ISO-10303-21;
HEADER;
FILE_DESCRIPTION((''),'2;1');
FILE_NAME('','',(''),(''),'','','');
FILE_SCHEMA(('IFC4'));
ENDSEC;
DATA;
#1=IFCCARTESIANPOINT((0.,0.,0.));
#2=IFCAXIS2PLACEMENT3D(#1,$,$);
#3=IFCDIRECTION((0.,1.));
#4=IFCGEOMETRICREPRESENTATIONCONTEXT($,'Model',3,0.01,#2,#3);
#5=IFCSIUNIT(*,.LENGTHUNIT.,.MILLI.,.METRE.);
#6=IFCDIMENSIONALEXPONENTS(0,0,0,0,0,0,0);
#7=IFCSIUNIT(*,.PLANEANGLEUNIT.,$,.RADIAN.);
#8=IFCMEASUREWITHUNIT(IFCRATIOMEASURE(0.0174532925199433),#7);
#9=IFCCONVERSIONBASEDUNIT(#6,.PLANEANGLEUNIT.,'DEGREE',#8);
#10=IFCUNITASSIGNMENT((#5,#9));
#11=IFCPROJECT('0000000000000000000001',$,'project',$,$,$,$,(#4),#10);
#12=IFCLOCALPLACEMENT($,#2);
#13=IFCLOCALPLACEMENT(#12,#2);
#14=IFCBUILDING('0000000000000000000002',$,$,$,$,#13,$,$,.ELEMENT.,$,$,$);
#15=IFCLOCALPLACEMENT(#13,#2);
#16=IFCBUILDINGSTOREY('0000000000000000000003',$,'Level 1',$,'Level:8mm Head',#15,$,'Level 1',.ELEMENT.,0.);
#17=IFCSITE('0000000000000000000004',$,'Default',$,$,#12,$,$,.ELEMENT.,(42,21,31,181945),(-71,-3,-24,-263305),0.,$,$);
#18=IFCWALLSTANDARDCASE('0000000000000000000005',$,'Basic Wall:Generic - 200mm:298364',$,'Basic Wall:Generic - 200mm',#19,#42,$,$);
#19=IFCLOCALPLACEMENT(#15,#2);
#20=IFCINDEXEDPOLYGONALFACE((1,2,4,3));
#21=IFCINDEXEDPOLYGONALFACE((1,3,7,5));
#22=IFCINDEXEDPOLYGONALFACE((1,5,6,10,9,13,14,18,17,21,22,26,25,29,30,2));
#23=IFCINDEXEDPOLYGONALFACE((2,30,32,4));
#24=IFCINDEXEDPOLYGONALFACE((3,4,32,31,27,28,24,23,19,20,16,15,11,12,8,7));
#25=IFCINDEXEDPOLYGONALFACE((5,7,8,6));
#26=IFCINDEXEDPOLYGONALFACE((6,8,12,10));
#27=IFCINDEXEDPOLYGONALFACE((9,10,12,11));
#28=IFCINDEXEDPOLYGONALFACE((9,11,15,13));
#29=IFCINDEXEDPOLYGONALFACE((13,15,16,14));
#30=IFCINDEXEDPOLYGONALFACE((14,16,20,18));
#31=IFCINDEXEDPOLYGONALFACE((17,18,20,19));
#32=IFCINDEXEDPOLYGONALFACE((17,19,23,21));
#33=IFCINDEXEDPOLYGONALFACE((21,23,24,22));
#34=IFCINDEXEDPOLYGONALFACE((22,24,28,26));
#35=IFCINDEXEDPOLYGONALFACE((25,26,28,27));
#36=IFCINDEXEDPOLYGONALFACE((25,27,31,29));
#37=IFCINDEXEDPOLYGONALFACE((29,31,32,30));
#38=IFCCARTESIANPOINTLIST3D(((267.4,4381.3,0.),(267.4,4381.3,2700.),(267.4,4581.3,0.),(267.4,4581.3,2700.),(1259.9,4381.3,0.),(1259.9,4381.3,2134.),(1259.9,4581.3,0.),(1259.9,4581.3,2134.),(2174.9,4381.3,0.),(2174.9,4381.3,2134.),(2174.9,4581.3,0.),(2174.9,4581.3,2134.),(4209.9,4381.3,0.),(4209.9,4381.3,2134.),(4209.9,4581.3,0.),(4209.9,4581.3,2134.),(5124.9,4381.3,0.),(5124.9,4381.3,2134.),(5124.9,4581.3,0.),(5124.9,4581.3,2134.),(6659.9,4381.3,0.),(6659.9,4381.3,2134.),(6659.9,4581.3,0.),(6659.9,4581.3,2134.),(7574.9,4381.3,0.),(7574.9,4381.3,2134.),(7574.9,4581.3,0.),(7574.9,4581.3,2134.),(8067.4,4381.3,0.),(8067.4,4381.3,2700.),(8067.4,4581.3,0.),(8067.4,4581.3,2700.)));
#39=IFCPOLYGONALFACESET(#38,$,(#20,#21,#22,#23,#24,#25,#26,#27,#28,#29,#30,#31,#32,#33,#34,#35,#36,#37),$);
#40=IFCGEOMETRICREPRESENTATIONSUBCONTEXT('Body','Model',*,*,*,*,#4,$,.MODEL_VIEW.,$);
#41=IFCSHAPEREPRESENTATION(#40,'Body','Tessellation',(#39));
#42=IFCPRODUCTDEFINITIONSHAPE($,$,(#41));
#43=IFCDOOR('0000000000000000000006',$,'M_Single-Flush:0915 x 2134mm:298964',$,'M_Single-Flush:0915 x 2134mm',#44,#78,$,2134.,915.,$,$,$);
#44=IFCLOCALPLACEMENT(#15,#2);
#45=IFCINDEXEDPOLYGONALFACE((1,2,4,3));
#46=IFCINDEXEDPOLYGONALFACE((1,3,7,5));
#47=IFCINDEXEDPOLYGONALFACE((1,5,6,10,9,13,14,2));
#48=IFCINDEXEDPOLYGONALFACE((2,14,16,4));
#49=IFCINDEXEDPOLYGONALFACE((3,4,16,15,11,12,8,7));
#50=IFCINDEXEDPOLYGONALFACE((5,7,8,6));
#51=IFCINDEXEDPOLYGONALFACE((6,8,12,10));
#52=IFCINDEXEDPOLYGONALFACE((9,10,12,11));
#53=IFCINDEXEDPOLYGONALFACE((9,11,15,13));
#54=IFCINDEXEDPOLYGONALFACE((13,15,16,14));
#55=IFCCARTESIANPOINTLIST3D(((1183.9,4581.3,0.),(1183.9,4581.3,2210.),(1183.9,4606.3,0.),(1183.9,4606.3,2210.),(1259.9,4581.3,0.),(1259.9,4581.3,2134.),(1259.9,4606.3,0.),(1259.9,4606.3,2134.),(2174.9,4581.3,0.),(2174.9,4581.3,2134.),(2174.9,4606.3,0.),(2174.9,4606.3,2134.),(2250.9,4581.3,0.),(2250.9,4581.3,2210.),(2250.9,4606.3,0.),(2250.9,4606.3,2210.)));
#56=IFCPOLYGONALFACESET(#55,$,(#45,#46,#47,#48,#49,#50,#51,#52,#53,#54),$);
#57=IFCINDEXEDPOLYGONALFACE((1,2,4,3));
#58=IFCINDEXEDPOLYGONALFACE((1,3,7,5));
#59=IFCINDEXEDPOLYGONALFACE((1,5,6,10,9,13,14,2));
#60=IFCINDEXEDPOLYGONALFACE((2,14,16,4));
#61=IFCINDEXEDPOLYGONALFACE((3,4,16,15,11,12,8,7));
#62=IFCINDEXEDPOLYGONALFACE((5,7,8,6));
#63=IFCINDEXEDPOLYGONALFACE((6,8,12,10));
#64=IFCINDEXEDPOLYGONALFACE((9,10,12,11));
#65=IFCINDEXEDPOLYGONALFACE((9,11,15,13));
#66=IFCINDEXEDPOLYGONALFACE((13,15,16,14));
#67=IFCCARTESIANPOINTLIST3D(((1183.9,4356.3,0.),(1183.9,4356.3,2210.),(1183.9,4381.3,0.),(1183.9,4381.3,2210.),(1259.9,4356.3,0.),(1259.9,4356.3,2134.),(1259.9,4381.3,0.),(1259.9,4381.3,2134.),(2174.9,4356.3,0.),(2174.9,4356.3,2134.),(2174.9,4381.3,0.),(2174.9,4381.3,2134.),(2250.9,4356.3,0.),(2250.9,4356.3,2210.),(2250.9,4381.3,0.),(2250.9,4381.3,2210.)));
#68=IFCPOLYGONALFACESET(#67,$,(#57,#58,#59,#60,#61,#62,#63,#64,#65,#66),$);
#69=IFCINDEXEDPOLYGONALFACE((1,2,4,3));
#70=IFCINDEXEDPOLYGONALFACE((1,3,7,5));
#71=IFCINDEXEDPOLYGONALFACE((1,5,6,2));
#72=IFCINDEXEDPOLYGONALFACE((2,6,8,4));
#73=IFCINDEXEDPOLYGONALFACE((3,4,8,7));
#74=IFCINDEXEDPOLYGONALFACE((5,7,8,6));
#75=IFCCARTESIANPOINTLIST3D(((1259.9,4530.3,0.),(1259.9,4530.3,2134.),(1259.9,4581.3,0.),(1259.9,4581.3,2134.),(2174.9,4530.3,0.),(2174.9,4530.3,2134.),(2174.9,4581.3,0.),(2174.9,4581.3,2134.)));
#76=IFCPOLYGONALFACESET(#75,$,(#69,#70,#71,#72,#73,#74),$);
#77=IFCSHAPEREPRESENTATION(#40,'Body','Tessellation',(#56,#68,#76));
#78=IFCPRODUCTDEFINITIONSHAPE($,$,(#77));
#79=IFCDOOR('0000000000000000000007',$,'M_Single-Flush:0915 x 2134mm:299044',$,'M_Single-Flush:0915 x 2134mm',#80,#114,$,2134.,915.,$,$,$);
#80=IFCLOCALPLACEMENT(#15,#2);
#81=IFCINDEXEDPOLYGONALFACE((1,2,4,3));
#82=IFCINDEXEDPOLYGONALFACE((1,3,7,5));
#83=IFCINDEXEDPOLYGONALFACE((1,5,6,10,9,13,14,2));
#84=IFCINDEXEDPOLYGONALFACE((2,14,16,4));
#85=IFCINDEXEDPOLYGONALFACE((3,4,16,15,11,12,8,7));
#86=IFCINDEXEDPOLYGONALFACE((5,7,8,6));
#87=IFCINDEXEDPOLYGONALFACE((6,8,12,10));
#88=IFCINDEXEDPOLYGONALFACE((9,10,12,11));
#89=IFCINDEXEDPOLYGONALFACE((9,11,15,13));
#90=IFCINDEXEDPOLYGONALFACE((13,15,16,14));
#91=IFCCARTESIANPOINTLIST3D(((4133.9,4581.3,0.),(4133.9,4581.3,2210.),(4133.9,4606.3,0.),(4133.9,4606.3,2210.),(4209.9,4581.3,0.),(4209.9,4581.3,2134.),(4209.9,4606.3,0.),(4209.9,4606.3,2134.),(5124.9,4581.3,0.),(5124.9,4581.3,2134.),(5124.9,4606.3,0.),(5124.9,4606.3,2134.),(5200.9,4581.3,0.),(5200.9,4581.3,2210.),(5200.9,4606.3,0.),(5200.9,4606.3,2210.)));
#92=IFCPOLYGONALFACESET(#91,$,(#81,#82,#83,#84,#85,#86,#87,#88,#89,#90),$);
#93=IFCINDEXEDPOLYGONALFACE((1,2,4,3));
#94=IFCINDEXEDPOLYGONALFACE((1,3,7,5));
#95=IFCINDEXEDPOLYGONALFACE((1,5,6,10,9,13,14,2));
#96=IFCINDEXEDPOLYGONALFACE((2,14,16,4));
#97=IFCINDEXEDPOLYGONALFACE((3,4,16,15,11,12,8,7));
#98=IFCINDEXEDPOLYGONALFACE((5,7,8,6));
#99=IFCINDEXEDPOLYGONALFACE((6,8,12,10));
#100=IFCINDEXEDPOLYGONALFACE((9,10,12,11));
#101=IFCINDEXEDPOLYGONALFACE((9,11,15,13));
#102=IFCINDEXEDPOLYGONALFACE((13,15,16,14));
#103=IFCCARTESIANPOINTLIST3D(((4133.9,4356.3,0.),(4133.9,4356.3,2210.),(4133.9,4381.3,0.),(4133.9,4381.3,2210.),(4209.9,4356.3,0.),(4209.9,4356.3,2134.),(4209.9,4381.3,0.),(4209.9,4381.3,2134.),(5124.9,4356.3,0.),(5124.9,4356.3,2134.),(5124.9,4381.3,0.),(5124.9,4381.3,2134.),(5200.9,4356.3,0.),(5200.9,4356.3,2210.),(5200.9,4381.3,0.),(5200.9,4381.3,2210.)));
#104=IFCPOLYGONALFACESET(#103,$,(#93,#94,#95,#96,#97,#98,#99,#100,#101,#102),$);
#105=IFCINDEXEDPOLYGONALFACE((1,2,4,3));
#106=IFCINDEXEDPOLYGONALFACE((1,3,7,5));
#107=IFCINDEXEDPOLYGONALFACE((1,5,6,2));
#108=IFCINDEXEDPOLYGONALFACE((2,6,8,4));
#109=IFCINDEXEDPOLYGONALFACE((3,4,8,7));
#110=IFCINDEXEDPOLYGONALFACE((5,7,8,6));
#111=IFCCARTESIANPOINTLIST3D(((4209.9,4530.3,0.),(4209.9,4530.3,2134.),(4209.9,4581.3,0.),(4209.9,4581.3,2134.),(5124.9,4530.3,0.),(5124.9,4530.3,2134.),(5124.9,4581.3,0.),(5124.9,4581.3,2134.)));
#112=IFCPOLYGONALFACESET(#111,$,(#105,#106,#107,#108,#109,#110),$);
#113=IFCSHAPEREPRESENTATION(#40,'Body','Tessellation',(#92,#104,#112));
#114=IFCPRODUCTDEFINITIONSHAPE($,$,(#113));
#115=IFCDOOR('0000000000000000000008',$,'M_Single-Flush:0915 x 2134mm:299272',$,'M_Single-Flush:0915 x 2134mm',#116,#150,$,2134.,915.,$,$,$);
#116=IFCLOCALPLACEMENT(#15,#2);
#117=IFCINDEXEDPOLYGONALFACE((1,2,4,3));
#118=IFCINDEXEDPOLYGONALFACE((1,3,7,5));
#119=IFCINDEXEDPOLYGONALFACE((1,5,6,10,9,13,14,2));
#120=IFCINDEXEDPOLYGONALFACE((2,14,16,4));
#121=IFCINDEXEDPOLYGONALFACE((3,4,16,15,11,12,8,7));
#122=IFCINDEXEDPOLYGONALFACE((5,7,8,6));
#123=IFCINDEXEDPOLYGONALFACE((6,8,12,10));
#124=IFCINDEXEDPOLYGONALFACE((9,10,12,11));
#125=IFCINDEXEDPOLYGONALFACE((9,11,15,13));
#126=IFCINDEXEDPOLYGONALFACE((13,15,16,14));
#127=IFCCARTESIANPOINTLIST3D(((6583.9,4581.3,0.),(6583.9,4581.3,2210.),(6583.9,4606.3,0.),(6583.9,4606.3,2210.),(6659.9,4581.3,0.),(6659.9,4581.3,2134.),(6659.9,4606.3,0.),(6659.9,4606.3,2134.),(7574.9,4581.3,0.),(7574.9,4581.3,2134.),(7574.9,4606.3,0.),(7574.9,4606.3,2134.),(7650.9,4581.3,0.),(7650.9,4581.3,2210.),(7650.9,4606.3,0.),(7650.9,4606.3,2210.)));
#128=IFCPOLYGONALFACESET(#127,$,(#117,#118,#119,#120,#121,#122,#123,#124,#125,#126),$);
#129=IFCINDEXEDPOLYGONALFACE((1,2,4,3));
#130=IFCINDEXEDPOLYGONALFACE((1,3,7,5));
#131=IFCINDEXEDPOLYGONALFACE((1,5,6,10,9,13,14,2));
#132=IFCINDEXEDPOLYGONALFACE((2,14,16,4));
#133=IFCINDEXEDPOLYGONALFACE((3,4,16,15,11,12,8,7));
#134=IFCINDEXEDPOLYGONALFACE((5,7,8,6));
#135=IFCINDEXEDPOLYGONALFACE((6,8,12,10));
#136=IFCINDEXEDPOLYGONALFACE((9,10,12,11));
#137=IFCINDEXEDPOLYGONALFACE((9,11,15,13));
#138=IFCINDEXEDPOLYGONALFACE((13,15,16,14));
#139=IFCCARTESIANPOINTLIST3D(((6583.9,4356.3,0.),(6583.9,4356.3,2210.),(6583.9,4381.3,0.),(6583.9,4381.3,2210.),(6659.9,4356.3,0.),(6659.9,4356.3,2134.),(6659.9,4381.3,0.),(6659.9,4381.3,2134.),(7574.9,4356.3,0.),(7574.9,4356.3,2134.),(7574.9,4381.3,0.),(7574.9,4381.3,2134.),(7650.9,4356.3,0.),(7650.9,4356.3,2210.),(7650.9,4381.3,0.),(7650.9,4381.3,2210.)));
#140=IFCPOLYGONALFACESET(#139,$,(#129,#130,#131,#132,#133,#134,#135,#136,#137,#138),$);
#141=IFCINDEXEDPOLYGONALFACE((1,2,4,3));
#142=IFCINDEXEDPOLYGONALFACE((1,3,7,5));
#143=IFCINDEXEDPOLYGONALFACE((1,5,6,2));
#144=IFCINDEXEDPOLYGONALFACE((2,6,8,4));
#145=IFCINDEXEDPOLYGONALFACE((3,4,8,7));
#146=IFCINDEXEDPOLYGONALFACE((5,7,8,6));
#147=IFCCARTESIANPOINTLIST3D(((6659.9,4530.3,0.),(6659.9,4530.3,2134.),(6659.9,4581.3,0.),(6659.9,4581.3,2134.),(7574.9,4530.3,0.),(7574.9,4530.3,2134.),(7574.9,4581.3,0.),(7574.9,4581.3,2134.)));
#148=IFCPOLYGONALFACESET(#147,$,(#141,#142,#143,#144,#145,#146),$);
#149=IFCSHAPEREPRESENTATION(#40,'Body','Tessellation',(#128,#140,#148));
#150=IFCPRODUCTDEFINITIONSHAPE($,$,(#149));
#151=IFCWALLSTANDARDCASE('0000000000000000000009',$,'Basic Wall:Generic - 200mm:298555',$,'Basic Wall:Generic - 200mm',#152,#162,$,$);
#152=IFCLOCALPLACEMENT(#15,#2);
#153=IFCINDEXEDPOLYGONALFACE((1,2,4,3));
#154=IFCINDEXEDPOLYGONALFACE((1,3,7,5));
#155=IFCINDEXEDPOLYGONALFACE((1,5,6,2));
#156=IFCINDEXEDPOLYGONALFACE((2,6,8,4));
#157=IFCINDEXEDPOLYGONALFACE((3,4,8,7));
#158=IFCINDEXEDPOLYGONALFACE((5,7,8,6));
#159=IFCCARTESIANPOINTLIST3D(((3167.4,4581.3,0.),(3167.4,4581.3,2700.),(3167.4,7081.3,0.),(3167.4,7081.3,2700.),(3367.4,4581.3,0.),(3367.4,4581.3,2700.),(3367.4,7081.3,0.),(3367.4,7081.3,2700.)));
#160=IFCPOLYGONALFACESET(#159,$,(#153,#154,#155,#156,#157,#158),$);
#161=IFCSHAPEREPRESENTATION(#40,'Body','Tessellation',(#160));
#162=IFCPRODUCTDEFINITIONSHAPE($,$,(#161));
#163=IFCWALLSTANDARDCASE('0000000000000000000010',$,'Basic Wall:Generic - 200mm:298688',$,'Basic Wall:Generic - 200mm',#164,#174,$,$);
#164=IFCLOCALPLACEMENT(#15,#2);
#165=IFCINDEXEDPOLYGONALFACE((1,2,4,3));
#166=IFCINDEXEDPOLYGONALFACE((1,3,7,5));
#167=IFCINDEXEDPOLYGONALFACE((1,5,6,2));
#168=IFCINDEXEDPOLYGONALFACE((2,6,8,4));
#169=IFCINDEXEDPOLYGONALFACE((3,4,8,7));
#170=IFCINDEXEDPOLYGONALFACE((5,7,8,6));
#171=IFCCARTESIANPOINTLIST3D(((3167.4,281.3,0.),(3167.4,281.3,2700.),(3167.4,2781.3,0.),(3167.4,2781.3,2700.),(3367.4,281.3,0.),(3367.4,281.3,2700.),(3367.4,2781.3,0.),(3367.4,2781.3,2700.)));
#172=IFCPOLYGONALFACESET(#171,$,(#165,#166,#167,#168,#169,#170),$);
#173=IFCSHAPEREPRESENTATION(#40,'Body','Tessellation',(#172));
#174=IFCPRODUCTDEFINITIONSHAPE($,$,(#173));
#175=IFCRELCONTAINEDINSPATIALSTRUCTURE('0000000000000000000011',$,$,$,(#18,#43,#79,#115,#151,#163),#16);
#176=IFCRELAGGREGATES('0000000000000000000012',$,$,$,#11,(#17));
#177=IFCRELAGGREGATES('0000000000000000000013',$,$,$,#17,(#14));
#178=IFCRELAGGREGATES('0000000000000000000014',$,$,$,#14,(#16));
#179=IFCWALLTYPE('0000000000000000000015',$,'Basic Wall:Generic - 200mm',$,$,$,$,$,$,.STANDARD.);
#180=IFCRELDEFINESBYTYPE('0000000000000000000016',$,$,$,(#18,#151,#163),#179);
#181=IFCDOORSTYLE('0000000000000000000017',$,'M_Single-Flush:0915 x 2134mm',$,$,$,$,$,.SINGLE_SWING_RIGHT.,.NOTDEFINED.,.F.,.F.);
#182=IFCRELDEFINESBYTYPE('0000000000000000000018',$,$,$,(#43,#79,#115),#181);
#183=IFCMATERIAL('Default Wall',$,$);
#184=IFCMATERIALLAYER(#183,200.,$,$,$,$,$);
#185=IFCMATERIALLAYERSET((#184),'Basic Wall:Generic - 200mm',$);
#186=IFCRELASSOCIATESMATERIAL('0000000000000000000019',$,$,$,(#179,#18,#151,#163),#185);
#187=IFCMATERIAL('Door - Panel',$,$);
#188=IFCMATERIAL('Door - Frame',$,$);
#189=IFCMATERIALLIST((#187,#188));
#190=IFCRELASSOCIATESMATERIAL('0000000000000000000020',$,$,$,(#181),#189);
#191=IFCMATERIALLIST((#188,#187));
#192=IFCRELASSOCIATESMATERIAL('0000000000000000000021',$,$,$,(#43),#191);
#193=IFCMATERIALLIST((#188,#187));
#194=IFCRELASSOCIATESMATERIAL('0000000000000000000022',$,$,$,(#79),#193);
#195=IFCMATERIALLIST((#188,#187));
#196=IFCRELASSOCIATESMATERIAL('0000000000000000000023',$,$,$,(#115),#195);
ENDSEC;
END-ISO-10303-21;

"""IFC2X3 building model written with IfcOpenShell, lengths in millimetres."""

from ifc_helpers import new_model, entity, si_unit, converted_unit, direction, frame, frame_2d, origin, place, context, subcontext, project, spatial, polyline, rectangle, outline, extrude, source, transform, mapped, material, material_list, layer, layer_set, layer_usage, type_object, type_shapes, element, fill, save


model = new_model("IFC2X3")

# Units and contexts
model_context = context("Model", 3, precision=0.01, world=origin(), true_north=direction((0.0, 1.0)))
body_context = subcontext(model_context, "Body", "Model", "MODEL_VIEW")
ifc_project = project(units=[si_unit("LENGTHUNIT", "METRE", prefix="MILLI"), converted_unit("PLANEANGLEUNIT", "DEGREE", entity("IfcRatioMeasure", 0.0174532925199433), si_unit("PLANEANGLEUNIT", "RADIAN"), dimensions=[0, 0, 0, 0, 0, 0, 0])], contexts=[model_context])

# Site, building, storey
site_placement = place(None, origin())
site = spatial("IfcSite", under=ifc_project, at=site_placement, Name="Default", CompositionType="ELEMENT", RefLatitude=(42, 21, 31, 181945), RefLongitude=(-71, -3, -24, -263305), RefElevation=0.0)
building_placement = place(site_placement, origin())
building = spatial("IfcBuilding", under=site, at=building_placement, CompositionType="ELEMENT")
storey_placement = place(building_placement, origin())
storey = spatial("IfcBuildingStorey", under=building, at=storey_placement, Name="Level 1", ObjectType="Level:8mm Head", LongName="Level 1", CompositionType="ELEMENT", Elevation=0.0)

# Shared definitions
ifc_material_1 = material(Name="Default Wall")
ifc_layer_1 = layer(ifc_material_1, 200.0)
ifc_layer_set_1 = layer_set([ifc_layer_1], Name="Basic Wall:Generic - 200mm")
wall_type = type_object("IfcWallType", Name="Basic Wall:Generic - 200mm", PredefinedType="STANDARD", material=ifc_layer_set_1)

# Shared definitions
ifc_material_2 = material(Name="Door - Frame")
ifc_material_3 = material(Name="Door - Panel")
ifc_material_list_1 = material_list([ifc_material_3, ifc_material_2])
door_style = type_object("IfcDoorStyle", Name="M_Single-Flush:0915 x 2134mm", ConstructionType="NOTDEFINED", OperationType="SINGLE_SWING_RIGHT", ParameterTakesPrecedence=False, Sizeable=False, material=ifc_material_list_1)
shared_shape_1 = source(origin(), body_context, "Body", "SweptSolid", [
    extrude(outline(polyline([(-533.5, -1124.0), (533.5, -1124.0), (533.5, 1086.0), (457.5, 1086.0), (457.5, -1048.0), (-457.5, -1048.0), (-457.5, 1086.0), (-533.5, 1086.0), (-533.5, -1124.0)])), frame((457.5, 200.0, 1086.0), z_axis=(0.0, 1.0, 0.0), x_axis=(1.0, 0.0, 0.0)), (0.0, 0.0, 1.0), 25.0),
    extrude(outline(polyline([(-1124.0, -533.5), (1086.0, -533.5), (1086.0, -457.5), (-1048.0, -457.5), (-1048.0, 457.5), (1086.0, 457.5), (1086.0, 533.5), (-1124.0, 533.5), (-1124.0, -533.5)])), frame((457.5, -25.0, 1086.0), z_axis=(0.0, 1.0, 0.0), x_axis=(0.0, 0.0, -1.0)), (0.0, 0.0, 1.0), 25.0),
    extrude(rectangle(XDim=51.0, YDim=915.0, at=frame_2d((0.0, 0.0), x_axis=(1.0, 0.0))), frame((457.5, 174.5, 0.0), z_axis=(0.0, 0.0, 1.0), x_axis=(0.0, 1.0, 0.0)), (0.0, 0.0, 1.0), 2134.0),
])
type_shapes(door_style, [shared_shape_1])

# Wall, openings, doors
ifc_layer_usage_1 = layer_usage(ifc_layer_set_1, "AXIS2", "NEGATIVE", 100.0)
wall_1_placement = place(storey_placement, frame((267.4, 4481.3, 0.0)))
wall_1 = element("IfcWallStandardCase", 1, at=wall_1_placement, inside=storey, type_object=wall_type, material=ifc_layer_usage_1, Name="Basic Wall:Generic - 200mm:298364", ObjectType="Basic Wall:Generic - 200mm", context=body_context, shape_type="SweptSolid", body=[
    extrude(rectangle(XDim=7800.0, YDim=200.0, at=frame_2d((3900.0, 0.0), x_axis=(-1.0, 0.0))), origin(), (0.0, 0.0, 1.0), 2700.0),
])
opening_1_placement = place(wall_1_placement, frame((992.5, -100.0, 0.0)))
opening_1 = element("IfcOpeningElement", 2, at=opening_1_placement, cuts=wall_1, ObjectType="Opening", context=body_context, shape_type="SweptSolid", body=[
    extrude(rectangle(XDim=915.0, YDim=2134.0, at=frame_2d((1067.0, 457.5), x_axis=(0.0, 1.0))), frame((0.0, 0.0, 0.0), z_axis=(0.0, 1.0, 0.0), x_axis=(0.0, 0.0, 1.0)), (0.0, 0.0, 1.0), 200.0),
])
opening_2_placement = place(wall_1_placement, frame((3942.5, -100.0, 0.0)))
opening_2 = element("IfcOpeningElement", 3, at=opening_2_placement, cuts=wall_1, ObjectType="Opening", context=body_context, shape_type="SweptSolid", body=[
    extrude(rectangle(XDim=915.0, YDim=2134.0, at=frame_2d((1067.0, 457.5), x_axis=(0.0, 1.0))), frame((0.0, 0.0, 0.0), z_axis=(0.0, 1.0, 0.0), x_axis=(0.0, 0.0, 1.0)), (0.0, 0.0, 1.0), 200.0),
])
opening_3_placement = place(wall_1_placement, frame((6392.5, -100.0, 0.0)))
opening_3 = element("IfcOpeningElement", 4, at=opening_3_placement, cuts=wall_1, ObjectType="Opening", context=body_context, shape_type="SweptSolid", body=[
    extrude(rectangle(XDim=915.0, YDim=2134.0, at=frame_2d((1067.0, 457.5), x_axis=(0.0, 1.0))), frame((0.0, 0.0, 0.0), z_axis=(0.0, 1.0, 0.0), x_axis=(0.0, 0.0, 1.0)), (0.0, 0.0, 1.0), 200.0),
])
ifc_material_list_2 = material_list([ifc_material_2, ifc_material_3])
door_1_placement = place(opening_1_placement, origin())
door_1 = element("IfcDoor", 5, at=door_1_placement, inside=storey, type_object=door_style, material=ifc_material_list_2, Name="M_Single-Flush:0915 x 2134mm:298964", ObjectType="M_Single-Flush:0915 x 2134mm", OverallHeight=2134.0, OverallWidth=915.0, context=body_context, shape_type="MappedRepresentation", body=[
    mapped(shared_shape_1, transform((0.0, 0.0, 0.0), scale=1.0)),
])
fill(opening_1, door_1)
ifc_material_list_3 = material_list([ifc_material_2, ifc_material_3])
door_2_placement = place(opening_2_placement, origin())
door_2 = element("IfcDoor", 6, at=door_2_placement, inside=storey, type_object=door_style, material=ifc_material_list_3, Name="M_Single-Flush:0915 x 2134mm:299044", ObjectType="M_Single-Flush:0915 x 2134mm", OverallHeight=2134.0, OverallWidth=915.0, context=body_context, shape_type="MappedRepresentation", body=[
    mapped(shared_shape_1, transform((0.0, 0.0, 0.0), scale=1.0)),
])
fill(opening_2, door_2)
ifc_material_list_4 = material_list([ifc_material_2, ifc_material_3])
door_3_placement = place(opening_3_placement, origin())
door_3 = element("IfcDoor", 7, at=door_3_placement, inside=storey, type_object=door_style, material=ifc_material_list_4, Name="M_Single-Flush:0915 x 2134mm:299272", ObjectType="M_Single-Flush:0915 x 2134mm", OverallHeight=2134.0, OverallWidth=915.0, context=body_context, shape_type="MappedRepresentation", body=[
    mapped(shared_shape_1, transform((0.0, 0.0, 0.0), scale=1.0)),
])
fill(opening_3, door_3)

# Walls
ifc_layer_usage_2 = layer_usage(ifc_layer_set_1, "AXIS2", "NEGATIVE", 100.0)
wall_2_placement = place(storey_placement, frame((3267.4, 7081.3, 0.0), z_axis=(0.0, 0.0, 1.0), x_axis=(0.0, -1.0, 0.0)))
element("IfcWallStandardCase", 8, at=wall_2_placement, inside=storey, type_object=wall_type, material=ifc_layer_usage_2, Name="Basic Wall:Generic - 200mm:298555", ObjectType="Basic Wall:Generic - 200mm", context=body_context, shape_type="SweptSolid", body=[
    extrude(rectangle(XDim=2500.0, YDim=200.0, at=frame_2d((1250.0, 0.0), x_axis=(-1.0, 0.0))), origin(), (0.0, 0.0, 1.0), 2700.0),
])
ifc_layer_usage_3 = layer_usage(ifc_layer_set_1, "AXIS2", "NEGATIVE", 100.0)
wall_3_placement = place(storey_placement, frame((3267.4, 2781.3, 0.0), z_axis=(0.0, 0.0, 1.0), x_axis=(0.0, -1.0, 0.0)))
element("IfcWallStandardCase", 9, at=wall_3_placement, inside=storey, type_object=wall_type, material=ifc_layer_usage_3, Name="Basic Wall:Generic - 200mm:298688", ObjectType="Basic Wall:Generic - 200mm", context=body_context, shape_type="SweptSolid", body=[
    extrude(rectangle(XDim=2500.0, YDim=200.0, at=frame_2d((1250.0, 0.0), x_axis=(-1.0, 0.0))), origin(), (0.0, 0.0, 1.0), 2700.0),
])

save(model, "model.ifc")
